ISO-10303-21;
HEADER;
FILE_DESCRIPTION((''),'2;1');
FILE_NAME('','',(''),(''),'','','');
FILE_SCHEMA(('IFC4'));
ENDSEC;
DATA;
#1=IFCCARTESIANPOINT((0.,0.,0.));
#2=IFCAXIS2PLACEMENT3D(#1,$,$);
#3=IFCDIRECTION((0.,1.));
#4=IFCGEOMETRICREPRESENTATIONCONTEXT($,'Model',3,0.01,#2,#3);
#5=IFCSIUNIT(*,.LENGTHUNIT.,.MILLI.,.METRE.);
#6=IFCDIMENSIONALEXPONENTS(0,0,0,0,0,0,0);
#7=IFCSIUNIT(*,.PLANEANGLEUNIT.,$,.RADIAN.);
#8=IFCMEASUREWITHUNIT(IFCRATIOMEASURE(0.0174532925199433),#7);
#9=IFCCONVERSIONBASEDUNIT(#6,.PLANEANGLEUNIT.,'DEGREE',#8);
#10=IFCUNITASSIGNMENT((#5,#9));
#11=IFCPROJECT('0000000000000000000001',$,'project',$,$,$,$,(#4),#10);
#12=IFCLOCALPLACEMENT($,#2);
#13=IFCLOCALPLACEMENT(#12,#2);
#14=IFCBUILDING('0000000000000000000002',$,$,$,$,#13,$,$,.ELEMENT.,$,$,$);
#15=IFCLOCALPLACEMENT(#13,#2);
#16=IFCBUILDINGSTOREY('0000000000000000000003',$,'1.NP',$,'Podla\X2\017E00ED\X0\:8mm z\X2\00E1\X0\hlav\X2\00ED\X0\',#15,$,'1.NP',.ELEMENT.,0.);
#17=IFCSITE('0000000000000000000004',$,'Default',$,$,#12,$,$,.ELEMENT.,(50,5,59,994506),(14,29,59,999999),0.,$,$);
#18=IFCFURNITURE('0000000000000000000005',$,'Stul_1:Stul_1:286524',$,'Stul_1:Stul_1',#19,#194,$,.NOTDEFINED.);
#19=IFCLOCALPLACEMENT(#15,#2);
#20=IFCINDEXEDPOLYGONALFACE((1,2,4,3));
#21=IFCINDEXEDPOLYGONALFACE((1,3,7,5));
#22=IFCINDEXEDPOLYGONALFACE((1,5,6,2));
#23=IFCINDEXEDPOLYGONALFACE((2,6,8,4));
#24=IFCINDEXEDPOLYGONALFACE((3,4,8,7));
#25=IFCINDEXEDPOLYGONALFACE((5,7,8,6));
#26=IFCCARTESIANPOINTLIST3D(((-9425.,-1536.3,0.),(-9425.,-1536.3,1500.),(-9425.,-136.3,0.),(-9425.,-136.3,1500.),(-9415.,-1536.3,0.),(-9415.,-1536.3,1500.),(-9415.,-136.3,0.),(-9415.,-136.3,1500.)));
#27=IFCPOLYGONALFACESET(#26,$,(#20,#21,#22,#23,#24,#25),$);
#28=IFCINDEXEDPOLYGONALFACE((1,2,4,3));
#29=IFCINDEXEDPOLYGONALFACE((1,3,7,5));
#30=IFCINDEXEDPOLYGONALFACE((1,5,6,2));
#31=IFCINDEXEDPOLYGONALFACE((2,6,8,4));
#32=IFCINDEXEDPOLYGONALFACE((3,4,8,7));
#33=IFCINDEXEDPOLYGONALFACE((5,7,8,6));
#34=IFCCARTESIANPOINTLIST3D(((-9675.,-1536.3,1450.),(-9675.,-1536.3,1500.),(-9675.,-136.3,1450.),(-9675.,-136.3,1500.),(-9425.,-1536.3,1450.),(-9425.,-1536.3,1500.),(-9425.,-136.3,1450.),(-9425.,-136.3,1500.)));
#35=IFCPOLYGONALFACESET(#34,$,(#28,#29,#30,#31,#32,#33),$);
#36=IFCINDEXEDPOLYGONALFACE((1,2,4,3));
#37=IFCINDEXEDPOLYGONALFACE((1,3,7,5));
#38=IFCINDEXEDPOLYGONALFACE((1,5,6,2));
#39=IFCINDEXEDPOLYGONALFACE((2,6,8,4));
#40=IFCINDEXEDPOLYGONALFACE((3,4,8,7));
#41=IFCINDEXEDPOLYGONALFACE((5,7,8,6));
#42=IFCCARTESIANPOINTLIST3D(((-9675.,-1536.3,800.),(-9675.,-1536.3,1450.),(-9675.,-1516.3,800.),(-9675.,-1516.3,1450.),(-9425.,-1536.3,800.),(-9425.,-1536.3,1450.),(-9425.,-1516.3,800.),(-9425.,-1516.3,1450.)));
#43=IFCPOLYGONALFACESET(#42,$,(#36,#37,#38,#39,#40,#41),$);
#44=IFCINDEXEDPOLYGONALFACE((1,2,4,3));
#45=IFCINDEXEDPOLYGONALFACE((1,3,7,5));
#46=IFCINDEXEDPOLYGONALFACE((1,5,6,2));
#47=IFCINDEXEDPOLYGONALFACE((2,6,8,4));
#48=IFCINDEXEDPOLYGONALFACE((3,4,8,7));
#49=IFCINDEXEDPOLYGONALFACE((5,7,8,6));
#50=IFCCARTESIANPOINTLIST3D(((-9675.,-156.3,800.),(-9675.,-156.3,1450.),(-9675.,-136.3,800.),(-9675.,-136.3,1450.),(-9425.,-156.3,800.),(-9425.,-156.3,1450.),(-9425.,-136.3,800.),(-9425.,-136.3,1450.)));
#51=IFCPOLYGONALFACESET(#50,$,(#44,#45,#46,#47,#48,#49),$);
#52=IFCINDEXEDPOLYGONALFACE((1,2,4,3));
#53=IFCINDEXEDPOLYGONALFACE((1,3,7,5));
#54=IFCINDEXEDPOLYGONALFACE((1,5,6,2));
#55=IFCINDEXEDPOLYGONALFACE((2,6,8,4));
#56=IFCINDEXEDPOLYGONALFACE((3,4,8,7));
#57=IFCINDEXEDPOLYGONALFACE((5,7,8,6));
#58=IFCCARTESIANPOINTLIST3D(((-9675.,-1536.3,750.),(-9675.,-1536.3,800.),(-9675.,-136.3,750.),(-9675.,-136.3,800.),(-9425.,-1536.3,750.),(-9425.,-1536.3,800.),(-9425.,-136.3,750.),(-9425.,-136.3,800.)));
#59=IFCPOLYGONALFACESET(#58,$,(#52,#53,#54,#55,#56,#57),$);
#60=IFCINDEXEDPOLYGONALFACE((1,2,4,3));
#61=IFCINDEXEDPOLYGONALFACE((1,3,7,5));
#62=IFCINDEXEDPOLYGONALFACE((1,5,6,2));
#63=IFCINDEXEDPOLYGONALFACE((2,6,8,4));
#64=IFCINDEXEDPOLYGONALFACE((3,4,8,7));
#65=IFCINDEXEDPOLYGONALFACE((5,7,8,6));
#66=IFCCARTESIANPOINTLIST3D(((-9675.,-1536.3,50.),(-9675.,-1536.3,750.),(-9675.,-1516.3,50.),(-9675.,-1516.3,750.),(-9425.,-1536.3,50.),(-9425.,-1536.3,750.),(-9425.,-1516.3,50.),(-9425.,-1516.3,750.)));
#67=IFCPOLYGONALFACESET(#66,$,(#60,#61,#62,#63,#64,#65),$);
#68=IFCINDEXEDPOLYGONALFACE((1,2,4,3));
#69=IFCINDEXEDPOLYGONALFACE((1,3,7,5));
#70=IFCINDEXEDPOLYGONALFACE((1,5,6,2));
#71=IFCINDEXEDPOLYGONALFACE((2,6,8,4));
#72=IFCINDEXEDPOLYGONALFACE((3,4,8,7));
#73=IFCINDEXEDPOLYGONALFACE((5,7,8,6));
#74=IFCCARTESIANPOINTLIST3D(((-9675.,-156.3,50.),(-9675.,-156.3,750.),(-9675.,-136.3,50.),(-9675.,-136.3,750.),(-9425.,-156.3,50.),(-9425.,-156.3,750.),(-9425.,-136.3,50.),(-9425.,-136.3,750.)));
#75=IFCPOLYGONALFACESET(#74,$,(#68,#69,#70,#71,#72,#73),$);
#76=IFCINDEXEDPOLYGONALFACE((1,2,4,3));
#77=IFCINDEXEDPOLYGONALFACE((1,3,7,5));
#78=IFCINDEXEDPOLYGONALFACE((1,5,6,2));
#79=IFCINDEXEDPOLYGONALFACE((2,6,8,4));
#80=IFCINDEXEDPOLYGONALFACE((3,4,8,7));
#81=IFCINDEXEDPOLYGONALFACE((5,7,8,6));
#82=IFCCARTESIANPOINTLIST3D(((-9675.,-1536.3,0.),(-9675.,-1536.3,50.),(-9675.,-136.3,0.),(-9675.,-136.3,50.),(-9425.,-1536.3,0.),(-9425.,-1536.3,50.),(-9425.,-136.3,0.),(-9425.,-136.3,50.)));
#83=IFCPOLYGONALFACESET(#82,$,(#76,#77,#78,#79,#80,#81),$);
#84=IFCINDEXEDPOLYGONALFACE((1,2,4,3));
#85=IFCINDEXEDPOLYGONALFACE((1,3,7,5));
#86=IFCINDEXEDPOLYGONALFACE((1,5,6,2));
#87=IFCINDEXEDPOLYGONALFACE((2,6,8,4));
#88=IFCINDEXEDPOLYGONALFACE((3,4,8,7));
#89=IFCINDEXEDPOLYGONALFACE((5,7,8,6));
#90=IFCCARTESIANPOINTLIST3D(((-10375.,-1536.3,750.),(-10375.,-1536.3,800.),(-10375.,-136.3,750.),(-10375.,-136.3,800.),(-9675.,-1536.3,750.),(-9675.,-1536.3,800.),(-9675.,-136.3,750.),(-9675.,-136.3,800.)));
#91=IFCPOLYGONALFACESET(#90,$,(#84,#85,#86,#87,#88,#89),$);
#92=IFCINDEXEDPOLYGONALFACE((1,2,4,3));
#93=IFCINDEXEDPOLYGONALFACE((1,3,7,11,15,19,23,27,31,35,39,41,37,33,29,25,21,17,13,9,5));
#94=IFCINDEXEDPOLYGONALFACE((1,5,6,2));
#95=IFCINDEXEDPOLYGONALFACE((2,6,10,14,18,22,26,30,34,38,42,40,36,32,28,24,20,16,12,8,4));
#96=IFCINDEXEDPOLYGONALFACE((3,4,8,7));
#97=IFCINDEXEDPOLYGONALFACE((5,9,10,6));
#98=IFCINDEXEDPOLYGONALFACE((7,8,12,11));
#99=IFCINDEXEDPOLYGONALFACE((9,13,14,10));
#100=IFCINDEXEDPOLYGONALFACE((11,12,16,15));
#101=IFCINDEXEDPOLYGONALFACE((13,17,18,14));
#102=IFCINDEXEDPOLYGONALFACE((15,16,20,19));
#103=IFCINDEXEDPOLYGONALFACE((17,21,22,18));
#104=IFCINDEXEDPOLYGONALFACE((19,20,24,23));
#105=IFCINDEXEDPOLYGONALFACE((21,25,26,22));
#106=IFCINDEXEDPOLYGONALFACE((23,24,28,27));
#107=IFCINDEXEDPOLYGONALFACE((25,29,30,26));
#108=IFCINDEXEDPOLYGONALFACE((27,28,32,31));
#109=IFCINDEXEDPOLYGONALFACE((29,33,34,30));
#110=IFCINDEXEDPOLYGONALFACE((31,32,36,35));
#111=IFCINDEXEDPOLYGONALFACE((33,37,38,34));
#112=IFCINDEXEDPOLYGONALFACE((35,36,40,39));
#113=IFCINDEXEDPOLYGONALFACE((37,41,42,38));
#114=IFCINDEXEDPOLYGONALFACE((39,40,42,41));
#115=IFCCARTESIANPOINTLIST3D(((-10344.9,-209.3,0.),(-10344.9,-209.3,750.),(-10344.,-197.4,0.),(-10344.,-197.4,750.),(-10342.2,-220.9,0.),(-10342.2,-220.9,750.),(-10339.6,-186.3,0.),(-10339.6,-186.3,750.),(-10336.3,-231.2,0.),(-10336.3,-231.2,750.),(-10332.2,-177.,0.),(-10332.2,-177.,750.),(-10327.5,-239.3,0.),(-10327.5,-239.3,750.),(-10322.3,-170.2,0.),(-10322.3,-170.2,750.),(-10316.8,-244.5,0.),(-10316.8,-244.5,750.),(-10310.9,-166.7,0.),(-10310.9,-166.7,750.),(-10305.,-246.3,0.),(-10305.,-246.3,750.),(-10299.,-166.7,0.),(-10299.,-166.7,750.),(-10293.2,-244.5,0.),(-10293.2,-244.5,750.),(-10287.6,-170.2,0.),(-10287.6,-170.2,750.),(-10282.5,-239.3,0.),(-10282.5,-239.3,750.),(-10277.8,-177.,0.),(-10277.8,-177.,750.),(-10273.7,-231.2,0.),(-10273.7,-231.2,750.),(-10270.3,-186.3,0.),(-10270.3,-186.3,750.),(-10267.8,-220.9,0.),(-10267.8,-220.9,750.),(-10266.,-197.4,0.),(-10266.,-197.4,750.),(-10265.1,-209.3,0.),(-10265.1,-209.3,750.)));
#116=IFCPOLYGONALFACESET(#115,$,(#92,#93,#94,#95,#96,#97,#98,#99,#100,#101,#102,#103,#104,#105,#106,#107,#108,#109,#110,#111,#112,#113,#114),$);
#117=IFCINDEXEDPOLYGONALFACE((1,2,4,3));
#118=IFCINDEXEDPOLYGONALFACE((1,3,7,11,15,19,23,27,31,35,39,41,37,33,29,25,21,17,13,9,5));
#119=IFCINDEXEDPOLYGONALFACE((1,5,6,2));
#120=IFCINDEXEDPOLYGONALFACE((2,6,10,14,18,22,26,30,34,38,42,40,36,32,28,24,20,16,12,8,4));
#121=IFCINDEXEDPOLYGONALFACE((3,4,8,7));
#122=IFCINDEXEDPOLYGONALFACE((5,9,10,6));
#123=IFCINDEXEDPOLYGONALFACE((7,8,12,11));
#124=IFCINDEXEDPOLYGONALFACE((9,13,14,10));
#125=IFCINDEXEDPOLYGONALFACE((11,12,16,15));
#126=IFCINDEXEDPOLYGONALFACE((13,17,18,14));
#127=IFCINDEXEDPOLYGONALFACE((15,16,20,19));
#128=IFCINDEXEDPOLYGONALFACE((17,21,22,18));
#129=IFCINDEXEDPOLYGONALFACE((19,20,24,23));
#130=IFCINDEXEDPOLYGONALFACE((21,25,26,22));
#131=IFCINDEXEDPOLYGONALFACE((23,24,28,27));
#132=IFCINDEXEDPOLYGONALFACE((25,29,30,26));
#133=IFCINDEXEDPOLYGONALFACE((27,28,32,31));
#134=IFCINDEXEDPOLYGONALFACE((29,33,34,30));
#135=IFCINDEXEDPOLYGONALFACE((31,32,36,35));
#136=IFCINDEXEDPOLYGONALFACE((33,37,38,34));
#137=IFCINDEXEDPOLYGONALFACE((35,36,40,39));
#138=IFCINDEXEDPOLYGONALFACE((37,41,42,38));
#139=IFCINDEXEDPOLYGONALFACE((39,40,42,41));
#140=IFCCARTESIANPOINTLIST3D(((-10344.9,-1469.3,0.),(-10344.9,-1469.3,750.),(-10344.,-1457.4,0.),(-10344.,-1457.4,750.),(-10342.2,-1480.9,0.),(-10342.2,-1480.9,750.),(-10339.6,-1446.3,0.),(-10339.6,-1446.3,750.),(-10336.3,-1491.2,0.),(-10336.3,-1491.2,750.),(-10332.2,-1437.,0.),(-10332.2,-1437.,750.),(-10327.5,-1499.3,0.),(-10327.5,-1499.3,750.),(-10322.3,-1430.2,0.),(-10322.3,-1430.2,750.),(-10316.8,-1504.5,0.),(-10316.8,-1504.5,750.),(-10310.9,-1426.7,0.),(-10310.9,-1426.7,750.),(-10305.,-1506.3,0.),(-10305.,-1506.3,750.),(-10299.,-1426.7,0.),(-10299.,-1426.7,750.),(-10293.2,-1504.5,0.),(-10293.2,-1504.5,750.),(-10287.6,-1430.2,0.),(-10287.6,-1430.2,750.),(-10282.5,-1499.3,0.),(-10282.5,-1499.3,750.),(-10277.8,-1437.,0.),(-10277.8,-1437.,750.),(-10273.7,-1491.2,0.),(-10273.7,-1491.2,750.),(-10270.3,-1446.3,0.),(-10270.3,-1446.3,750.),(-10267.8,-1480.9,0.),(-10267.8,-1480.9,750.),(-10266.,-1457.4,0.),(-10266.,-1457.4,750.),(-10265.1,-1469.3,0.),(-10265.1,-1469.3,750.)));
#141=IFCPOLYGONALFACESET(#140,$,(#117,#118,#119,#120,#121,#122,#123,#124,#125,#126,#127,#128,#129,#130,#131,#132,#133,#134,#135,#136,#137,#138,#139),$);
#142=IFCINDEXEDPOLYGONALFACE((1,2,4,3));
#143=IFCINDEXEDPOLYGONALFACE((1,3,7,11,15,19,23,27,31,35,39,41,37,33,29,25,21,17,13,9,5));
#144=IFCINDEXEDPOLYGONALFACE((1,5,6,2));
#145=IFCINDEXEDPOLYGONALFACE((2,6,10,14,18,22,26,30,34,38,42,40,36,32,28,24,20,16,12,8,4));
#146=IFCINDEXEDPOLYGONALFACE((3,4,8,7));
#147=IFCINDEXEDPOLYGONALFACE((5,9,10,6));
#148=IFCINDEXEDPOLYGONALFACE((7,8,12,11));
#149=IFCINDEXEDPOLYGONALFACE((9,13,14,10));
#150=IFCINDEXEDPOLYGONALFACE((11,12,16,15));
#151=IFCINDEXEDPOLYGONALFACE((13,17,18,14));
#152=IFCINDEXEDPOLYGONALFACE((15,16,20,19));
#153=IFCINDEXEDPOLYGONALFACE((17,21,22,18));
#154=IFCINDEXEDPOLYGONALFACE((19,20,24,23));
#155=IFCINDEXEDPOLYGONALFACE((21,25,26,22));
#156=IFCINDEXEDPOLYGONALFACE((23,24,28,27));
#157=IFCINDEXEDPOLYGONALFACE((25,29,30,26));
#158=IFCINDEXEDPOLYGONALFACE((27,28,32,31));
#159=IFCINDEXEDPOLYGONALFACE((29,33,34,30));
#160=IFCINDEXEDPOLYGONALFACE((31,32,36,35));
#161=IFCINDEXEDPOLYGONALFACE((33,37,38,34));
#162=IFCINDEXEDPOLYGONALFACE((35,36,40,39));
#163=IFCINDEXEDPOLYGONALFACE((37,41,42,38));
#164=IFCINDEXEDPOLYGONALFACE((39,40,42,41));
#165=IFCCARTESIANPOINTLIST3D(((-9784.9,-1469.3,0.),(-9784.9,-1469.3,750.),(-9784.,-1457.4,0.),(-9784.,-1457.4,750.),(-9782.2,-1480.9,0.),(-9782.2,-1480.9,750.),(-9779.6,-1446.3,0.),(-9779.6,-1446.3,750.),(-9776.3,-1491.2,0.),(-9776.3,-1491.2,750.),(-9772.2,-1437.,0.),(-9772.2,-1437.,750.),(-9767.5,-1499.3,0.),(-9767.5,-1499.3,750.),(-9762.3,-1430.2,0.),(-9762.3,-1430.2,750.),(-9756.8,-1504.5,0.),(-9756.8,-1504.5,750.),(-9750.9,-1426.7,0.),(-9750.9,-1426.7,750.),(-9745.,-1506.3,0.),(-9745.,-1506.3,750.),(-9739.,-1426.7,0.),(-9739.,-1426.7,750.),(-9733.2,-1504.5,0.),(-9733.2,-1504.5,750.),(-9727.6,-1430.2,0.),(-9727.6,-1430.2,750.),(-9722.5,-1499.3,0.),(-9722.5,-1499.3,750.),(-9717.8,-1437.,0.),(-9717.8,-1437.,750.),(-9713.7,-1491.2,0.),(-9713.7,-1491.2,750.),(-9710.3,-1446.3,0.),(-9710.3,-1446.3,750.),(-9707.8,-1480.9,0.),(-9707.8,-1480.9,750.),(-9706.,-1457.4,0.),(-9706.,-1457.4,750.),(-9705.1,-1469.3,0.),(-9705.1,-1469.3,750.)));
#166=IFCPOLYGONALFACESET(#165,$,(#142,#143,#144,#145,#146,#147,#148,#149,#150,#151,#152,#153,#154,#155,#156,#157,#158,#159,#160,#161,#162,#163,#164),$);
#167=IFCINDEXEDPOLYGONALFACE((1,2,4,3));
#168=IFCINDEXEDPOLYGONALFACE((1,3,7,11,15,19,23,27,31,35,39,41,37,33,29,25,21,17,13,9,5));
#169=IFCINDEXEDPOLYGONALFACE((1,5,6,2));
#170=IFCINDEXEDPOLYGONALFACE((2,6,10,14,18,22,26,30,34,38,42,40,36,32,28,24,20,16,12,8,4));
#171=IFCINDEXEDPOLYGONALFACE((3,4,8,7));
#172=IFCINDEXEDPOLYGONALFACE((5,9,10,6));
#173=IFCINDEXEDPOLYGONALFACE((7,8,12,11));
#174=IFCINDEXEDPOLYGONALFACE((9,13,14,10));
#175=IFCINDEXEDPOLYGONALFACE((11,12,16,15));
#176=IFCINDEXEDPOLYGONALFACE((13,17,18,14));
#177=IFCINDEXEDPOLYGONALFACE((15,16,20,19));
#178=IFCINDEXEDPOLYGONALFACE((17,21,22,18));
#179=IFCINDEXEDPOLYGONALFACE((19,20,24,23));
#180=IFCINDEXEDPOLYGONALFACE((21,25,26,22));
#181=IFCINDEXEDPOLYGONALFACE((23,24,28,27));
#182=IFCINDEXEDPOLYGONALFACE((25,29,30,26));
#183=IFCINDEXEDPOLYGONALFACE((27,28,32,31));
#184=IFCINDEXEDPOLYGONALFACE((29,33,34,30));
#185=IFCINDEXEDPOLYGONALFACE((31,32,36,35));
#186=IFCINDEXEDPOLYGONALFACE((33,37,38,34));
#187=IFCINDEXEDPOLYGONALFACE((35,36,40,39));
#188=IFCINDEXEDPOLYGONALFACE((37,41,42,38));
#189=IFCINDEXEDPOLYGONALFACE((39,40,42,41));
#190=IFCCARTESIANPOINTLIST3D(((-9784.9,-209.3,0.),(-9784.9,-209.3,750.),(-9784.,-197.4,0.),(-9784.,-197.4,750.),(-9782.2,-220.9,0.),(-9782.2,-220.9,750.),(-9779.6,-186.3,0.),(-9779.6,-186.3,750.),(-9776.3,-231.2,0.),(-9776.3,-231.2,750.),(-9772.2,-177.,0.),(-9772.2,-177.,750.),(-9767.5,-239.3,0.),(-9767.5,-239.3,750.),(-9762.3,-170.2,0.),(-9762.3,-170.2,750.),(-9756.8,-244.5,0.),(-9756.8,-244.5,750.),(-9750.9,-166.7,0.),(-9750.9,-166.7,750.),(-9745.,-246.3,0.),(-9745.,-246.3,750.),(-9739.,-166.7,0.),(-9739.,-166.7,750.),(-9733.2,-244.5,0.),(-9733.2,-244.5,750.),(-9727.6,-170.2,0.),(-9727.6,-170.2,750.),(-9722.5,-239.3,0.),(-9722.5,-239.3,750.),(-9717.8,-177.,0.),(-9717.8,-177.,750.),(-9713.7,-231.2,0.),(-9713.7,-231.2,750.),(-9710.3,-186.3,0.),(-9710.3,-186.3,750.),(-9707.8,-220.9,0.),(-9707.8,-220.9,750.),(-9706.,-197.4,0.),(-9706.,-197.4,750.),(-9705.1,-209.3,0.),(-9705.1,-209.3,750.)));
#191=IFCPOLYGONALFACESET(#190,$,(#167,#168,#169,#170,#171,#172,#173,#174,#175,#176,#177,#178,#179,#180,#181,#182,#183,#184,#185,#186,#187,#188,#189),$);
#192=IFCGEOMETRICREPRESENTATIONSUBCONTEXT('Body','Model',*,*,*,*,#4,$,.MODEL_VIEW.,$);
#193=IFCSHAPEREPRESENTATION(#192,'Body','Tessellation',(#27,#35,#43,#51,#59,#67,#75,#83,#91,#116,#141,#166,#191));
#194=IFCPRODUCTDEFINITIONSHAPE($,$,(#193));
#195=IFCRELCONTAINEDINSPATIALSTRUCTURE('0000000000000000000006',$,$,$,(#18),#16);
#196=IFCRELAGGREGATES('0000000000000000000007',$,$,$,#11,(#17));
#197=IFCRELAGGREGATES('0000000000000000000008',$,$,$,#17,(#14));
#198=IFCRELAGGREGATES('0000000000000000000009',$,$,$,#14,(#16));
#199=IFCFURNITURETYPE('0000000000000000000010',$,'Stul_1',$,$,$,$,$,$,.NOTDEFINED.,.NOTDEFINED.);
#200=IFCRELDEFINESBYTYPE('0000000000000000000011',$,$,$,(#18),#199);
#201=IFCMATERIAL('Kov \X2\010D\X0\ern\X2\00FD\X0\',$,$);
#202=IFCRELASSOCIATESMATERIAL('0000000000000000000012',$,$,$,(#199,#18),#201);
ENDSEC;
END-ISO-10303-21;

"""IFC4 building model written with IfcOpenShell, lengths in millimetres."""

from ifc_helpers import new_model, entity, si_unit, converted_unit, direction, frame, frame_2d, origin, origin_2d_with_axis, place, context, subcontext, project, spatial, rectangle, circle, extrude, source, transform, mapped, material, type_object, type_shapes, element, save


model = new_model("IFC4")

# Units and contexts
model_context = context("Model", 3, precision=0.01, world=origin(), true_north=direction((0.0, 1.0)))
body_context = subcontext(model_context, "Body", "Model", "MODEL_VIEW")
ifc_project = project(units=[si_unit("LENGTHUNIT", "METRE", prefix="MILLI"), converted_unit("PLANEANGLEUNIT", "DEGREE", entity("IfcRatioMeasure", 0.0174532925199433), si_unit("PLANEANGLEUNIT", "RADIAN"), dimensions=[0, 0, 0, 0, 0, 0, 0])], contexts=[model_context])

# Site, building, storey
site_placement = place(None, origin())
site = spatial("IfcSite", under=ifc_project, at=site_placement, Name="Default", CompositionType="ELEMENT", RefLatitude=(50, 5, 59, 994506), RefLongitude=(14, 29, 59, 999999), RefElevation=0.0)
building_placement = place(site_placement, origin())
building = spatial("IfcBuilding", under=site, at=building_placement, CompositionType="ELEMENT")
storey_placement = place(building_placement, origin())
storey = spatial("IfcBuildingStorey", under=building, at=storey_placement, Name="1.NP", ObjectType="Podlaží:8mm záhlaví", LongName="1.NP", CompositionType="ELEMENT", Elevation=0.0)

# Furniture
ifc_material_1 = material(Name="Kov černý")
furniture_type = type_object("IfcFurnitureType", Name="Stul_1", AssemblyPlace="NOTDEFINED", PredefinedType="NOTDEFINED", material=ifc_material_1)
shared_shape_1 = source(origin(), body_context, "Body", "SweptSolid", [
    extrude(rectangle(XDim=1400.0, YDim=10.0, at=origin_2d_with_axis()), frame((0.0, 605.0, 0.0), z_axis=(0.0, 0.0, 1.0), x_axis=(-1.0, 0.0, 0.0)), (0.0, 0.0, 1.0), 1500.0),
    extrude(rectangle(XDim=1400.0, YDim=250.0, at=frame_2d((0.0, 0.0), x_axis=(1.0, 0.0))), frame((0.0, 475.0, 1450.0), z_axis=(0.0, 0.0, 1.0), x_axis=(-1.0, 0.0, 0.0)), (0.0, 0.0, 1.0), 50.0),
    extrude(rectangle(XDim=20.0, YDim=250.0, at=origin_2d_with_axis()), frame((690.0, 475.0, 800.0), z_axis=(0.0, 0.0, 1.0), x_axis=(-1.0, 0.0, 0.0)), (0.0, 0.0, 1.0), 650.0),
    extrude(rectangle(XDim=20.0, YDim=250.0, at=frame_2d((0.0, 0.0), x_axis=(1.0, 0.0))), frame((-690.0, 475.0, 800.0), z_axis=(0.0, 0.0, 1.0), x_axis=(-1.0, 0.0, 0.0)), (0.0, 0.0, 1.0), 650.0),
    extrude(rectangle(XDim=1400.0, YDim=250.0, at=origin_2d_with_axis()), frame((0.0, 475.0, 750.0), z_axis=(0.0, 0.0, 1.0), x_axis=(-1.0, 0.0, 0.0)), (0.0, 0.0, 1.0), 50.0),
    extrude(rectangle(XDim=20.0, YDim=250.0, at=origin_2d_with_axis()), frame((690.0, 475.0, 50.0), z_axis=(0.0, 0.0, 1.0), x_axis=(-1.0, 0.0, 0.0)), (0.0, 0.0, 1.0), 700.0),
    extrude(rectangle(XDim=20.0, YDim=250.0, at=frame_2d((0.0, 0.0), x_axis=(1.0, 0.0))), frame((-690.0, 475.0, 50.0), z_axis=(0.0, 0.0, 1.0), x_axis=(-1.0, 0.0, 0.0)), (0.0, 0.0, 1.0), 700.0),
    extrude(rectangle(XDim=1400.0, YDim=250.0, at=origin_2d_with_axis()), frame((0.0, 475.0, 0.0), z_axis=(0.0, 0.0, 1.0), x_axis=(-1.0, 0.0, 0.0)), (0.0, 0.0, 1.0), 50.0),
    extrude(rectangle(XDim=1400.0, YDim=700.0, at=origin_2d_with_axis()), frame((0.0, 0.0, 750.0), z_axis=(0.0, 0.0, 1.0), x_axis=(-1.0, 0.0, 0.0)), (0.0, 0.0, 1.0), 50.0),
    extrude(circle(Radius=40.0, at=frame_2d((0.0, 0.0), x_axis=(1.0, 0.0))), frame((-630.0, -280.0, 0.0)), (0.0, 0.0, 1.0), 750.0),
    extrude(circle(Radius=40.0, at=frame_2d((0.0, 0.0), x_axis=(1.0, 0.0))), frame((630.0, -280.0, 0.0)), (0.0, 0.0, 1.0), 750.0),
    extrude(circle(Radius=40.0, at=frame_2d((0.0, 0.0), x_axis=(1.0, 0.0))), frame((630.0, 280.0, 0.0)), (0.0, 0.0, 1.0), 750.0),
    extrude(circle(Radius=40.0, at=frame_2d((0.0, 0.0), x_axis=(1.0, 0.0))), frame((-630.0, 280.0, 0.0)), (0.0, 0.0, 1.0), 750.0),
])
type_shapes(furniture_type, [shared_shape_1])
for number, where, z_axis, x_axis, name in (
    (1, (-10025.0, -836.3, 0.0), (0.0, 0.0, 1.0), (0.0, -1.0, 0.0), "Stul_1:Stul_1:286524"),
):
    element("IfcFurniture", number, at=place(storey_placement, frame(where, z_axis=z_axis, x_axis=x_axis)), inside=storey, type_object=furniture_type, material=ifc_material_1, Name=name, ObjectType="Stul_1:Stul_1", PredefinedType="NOTDEFINED", context=body_context, shape_type="MappedRepresentation", body=[
        mapped(shared_shape_1, transform((0.0, 0.0, 0.0), scale=1.0)),
    ])

save(model, "model.ifc")
